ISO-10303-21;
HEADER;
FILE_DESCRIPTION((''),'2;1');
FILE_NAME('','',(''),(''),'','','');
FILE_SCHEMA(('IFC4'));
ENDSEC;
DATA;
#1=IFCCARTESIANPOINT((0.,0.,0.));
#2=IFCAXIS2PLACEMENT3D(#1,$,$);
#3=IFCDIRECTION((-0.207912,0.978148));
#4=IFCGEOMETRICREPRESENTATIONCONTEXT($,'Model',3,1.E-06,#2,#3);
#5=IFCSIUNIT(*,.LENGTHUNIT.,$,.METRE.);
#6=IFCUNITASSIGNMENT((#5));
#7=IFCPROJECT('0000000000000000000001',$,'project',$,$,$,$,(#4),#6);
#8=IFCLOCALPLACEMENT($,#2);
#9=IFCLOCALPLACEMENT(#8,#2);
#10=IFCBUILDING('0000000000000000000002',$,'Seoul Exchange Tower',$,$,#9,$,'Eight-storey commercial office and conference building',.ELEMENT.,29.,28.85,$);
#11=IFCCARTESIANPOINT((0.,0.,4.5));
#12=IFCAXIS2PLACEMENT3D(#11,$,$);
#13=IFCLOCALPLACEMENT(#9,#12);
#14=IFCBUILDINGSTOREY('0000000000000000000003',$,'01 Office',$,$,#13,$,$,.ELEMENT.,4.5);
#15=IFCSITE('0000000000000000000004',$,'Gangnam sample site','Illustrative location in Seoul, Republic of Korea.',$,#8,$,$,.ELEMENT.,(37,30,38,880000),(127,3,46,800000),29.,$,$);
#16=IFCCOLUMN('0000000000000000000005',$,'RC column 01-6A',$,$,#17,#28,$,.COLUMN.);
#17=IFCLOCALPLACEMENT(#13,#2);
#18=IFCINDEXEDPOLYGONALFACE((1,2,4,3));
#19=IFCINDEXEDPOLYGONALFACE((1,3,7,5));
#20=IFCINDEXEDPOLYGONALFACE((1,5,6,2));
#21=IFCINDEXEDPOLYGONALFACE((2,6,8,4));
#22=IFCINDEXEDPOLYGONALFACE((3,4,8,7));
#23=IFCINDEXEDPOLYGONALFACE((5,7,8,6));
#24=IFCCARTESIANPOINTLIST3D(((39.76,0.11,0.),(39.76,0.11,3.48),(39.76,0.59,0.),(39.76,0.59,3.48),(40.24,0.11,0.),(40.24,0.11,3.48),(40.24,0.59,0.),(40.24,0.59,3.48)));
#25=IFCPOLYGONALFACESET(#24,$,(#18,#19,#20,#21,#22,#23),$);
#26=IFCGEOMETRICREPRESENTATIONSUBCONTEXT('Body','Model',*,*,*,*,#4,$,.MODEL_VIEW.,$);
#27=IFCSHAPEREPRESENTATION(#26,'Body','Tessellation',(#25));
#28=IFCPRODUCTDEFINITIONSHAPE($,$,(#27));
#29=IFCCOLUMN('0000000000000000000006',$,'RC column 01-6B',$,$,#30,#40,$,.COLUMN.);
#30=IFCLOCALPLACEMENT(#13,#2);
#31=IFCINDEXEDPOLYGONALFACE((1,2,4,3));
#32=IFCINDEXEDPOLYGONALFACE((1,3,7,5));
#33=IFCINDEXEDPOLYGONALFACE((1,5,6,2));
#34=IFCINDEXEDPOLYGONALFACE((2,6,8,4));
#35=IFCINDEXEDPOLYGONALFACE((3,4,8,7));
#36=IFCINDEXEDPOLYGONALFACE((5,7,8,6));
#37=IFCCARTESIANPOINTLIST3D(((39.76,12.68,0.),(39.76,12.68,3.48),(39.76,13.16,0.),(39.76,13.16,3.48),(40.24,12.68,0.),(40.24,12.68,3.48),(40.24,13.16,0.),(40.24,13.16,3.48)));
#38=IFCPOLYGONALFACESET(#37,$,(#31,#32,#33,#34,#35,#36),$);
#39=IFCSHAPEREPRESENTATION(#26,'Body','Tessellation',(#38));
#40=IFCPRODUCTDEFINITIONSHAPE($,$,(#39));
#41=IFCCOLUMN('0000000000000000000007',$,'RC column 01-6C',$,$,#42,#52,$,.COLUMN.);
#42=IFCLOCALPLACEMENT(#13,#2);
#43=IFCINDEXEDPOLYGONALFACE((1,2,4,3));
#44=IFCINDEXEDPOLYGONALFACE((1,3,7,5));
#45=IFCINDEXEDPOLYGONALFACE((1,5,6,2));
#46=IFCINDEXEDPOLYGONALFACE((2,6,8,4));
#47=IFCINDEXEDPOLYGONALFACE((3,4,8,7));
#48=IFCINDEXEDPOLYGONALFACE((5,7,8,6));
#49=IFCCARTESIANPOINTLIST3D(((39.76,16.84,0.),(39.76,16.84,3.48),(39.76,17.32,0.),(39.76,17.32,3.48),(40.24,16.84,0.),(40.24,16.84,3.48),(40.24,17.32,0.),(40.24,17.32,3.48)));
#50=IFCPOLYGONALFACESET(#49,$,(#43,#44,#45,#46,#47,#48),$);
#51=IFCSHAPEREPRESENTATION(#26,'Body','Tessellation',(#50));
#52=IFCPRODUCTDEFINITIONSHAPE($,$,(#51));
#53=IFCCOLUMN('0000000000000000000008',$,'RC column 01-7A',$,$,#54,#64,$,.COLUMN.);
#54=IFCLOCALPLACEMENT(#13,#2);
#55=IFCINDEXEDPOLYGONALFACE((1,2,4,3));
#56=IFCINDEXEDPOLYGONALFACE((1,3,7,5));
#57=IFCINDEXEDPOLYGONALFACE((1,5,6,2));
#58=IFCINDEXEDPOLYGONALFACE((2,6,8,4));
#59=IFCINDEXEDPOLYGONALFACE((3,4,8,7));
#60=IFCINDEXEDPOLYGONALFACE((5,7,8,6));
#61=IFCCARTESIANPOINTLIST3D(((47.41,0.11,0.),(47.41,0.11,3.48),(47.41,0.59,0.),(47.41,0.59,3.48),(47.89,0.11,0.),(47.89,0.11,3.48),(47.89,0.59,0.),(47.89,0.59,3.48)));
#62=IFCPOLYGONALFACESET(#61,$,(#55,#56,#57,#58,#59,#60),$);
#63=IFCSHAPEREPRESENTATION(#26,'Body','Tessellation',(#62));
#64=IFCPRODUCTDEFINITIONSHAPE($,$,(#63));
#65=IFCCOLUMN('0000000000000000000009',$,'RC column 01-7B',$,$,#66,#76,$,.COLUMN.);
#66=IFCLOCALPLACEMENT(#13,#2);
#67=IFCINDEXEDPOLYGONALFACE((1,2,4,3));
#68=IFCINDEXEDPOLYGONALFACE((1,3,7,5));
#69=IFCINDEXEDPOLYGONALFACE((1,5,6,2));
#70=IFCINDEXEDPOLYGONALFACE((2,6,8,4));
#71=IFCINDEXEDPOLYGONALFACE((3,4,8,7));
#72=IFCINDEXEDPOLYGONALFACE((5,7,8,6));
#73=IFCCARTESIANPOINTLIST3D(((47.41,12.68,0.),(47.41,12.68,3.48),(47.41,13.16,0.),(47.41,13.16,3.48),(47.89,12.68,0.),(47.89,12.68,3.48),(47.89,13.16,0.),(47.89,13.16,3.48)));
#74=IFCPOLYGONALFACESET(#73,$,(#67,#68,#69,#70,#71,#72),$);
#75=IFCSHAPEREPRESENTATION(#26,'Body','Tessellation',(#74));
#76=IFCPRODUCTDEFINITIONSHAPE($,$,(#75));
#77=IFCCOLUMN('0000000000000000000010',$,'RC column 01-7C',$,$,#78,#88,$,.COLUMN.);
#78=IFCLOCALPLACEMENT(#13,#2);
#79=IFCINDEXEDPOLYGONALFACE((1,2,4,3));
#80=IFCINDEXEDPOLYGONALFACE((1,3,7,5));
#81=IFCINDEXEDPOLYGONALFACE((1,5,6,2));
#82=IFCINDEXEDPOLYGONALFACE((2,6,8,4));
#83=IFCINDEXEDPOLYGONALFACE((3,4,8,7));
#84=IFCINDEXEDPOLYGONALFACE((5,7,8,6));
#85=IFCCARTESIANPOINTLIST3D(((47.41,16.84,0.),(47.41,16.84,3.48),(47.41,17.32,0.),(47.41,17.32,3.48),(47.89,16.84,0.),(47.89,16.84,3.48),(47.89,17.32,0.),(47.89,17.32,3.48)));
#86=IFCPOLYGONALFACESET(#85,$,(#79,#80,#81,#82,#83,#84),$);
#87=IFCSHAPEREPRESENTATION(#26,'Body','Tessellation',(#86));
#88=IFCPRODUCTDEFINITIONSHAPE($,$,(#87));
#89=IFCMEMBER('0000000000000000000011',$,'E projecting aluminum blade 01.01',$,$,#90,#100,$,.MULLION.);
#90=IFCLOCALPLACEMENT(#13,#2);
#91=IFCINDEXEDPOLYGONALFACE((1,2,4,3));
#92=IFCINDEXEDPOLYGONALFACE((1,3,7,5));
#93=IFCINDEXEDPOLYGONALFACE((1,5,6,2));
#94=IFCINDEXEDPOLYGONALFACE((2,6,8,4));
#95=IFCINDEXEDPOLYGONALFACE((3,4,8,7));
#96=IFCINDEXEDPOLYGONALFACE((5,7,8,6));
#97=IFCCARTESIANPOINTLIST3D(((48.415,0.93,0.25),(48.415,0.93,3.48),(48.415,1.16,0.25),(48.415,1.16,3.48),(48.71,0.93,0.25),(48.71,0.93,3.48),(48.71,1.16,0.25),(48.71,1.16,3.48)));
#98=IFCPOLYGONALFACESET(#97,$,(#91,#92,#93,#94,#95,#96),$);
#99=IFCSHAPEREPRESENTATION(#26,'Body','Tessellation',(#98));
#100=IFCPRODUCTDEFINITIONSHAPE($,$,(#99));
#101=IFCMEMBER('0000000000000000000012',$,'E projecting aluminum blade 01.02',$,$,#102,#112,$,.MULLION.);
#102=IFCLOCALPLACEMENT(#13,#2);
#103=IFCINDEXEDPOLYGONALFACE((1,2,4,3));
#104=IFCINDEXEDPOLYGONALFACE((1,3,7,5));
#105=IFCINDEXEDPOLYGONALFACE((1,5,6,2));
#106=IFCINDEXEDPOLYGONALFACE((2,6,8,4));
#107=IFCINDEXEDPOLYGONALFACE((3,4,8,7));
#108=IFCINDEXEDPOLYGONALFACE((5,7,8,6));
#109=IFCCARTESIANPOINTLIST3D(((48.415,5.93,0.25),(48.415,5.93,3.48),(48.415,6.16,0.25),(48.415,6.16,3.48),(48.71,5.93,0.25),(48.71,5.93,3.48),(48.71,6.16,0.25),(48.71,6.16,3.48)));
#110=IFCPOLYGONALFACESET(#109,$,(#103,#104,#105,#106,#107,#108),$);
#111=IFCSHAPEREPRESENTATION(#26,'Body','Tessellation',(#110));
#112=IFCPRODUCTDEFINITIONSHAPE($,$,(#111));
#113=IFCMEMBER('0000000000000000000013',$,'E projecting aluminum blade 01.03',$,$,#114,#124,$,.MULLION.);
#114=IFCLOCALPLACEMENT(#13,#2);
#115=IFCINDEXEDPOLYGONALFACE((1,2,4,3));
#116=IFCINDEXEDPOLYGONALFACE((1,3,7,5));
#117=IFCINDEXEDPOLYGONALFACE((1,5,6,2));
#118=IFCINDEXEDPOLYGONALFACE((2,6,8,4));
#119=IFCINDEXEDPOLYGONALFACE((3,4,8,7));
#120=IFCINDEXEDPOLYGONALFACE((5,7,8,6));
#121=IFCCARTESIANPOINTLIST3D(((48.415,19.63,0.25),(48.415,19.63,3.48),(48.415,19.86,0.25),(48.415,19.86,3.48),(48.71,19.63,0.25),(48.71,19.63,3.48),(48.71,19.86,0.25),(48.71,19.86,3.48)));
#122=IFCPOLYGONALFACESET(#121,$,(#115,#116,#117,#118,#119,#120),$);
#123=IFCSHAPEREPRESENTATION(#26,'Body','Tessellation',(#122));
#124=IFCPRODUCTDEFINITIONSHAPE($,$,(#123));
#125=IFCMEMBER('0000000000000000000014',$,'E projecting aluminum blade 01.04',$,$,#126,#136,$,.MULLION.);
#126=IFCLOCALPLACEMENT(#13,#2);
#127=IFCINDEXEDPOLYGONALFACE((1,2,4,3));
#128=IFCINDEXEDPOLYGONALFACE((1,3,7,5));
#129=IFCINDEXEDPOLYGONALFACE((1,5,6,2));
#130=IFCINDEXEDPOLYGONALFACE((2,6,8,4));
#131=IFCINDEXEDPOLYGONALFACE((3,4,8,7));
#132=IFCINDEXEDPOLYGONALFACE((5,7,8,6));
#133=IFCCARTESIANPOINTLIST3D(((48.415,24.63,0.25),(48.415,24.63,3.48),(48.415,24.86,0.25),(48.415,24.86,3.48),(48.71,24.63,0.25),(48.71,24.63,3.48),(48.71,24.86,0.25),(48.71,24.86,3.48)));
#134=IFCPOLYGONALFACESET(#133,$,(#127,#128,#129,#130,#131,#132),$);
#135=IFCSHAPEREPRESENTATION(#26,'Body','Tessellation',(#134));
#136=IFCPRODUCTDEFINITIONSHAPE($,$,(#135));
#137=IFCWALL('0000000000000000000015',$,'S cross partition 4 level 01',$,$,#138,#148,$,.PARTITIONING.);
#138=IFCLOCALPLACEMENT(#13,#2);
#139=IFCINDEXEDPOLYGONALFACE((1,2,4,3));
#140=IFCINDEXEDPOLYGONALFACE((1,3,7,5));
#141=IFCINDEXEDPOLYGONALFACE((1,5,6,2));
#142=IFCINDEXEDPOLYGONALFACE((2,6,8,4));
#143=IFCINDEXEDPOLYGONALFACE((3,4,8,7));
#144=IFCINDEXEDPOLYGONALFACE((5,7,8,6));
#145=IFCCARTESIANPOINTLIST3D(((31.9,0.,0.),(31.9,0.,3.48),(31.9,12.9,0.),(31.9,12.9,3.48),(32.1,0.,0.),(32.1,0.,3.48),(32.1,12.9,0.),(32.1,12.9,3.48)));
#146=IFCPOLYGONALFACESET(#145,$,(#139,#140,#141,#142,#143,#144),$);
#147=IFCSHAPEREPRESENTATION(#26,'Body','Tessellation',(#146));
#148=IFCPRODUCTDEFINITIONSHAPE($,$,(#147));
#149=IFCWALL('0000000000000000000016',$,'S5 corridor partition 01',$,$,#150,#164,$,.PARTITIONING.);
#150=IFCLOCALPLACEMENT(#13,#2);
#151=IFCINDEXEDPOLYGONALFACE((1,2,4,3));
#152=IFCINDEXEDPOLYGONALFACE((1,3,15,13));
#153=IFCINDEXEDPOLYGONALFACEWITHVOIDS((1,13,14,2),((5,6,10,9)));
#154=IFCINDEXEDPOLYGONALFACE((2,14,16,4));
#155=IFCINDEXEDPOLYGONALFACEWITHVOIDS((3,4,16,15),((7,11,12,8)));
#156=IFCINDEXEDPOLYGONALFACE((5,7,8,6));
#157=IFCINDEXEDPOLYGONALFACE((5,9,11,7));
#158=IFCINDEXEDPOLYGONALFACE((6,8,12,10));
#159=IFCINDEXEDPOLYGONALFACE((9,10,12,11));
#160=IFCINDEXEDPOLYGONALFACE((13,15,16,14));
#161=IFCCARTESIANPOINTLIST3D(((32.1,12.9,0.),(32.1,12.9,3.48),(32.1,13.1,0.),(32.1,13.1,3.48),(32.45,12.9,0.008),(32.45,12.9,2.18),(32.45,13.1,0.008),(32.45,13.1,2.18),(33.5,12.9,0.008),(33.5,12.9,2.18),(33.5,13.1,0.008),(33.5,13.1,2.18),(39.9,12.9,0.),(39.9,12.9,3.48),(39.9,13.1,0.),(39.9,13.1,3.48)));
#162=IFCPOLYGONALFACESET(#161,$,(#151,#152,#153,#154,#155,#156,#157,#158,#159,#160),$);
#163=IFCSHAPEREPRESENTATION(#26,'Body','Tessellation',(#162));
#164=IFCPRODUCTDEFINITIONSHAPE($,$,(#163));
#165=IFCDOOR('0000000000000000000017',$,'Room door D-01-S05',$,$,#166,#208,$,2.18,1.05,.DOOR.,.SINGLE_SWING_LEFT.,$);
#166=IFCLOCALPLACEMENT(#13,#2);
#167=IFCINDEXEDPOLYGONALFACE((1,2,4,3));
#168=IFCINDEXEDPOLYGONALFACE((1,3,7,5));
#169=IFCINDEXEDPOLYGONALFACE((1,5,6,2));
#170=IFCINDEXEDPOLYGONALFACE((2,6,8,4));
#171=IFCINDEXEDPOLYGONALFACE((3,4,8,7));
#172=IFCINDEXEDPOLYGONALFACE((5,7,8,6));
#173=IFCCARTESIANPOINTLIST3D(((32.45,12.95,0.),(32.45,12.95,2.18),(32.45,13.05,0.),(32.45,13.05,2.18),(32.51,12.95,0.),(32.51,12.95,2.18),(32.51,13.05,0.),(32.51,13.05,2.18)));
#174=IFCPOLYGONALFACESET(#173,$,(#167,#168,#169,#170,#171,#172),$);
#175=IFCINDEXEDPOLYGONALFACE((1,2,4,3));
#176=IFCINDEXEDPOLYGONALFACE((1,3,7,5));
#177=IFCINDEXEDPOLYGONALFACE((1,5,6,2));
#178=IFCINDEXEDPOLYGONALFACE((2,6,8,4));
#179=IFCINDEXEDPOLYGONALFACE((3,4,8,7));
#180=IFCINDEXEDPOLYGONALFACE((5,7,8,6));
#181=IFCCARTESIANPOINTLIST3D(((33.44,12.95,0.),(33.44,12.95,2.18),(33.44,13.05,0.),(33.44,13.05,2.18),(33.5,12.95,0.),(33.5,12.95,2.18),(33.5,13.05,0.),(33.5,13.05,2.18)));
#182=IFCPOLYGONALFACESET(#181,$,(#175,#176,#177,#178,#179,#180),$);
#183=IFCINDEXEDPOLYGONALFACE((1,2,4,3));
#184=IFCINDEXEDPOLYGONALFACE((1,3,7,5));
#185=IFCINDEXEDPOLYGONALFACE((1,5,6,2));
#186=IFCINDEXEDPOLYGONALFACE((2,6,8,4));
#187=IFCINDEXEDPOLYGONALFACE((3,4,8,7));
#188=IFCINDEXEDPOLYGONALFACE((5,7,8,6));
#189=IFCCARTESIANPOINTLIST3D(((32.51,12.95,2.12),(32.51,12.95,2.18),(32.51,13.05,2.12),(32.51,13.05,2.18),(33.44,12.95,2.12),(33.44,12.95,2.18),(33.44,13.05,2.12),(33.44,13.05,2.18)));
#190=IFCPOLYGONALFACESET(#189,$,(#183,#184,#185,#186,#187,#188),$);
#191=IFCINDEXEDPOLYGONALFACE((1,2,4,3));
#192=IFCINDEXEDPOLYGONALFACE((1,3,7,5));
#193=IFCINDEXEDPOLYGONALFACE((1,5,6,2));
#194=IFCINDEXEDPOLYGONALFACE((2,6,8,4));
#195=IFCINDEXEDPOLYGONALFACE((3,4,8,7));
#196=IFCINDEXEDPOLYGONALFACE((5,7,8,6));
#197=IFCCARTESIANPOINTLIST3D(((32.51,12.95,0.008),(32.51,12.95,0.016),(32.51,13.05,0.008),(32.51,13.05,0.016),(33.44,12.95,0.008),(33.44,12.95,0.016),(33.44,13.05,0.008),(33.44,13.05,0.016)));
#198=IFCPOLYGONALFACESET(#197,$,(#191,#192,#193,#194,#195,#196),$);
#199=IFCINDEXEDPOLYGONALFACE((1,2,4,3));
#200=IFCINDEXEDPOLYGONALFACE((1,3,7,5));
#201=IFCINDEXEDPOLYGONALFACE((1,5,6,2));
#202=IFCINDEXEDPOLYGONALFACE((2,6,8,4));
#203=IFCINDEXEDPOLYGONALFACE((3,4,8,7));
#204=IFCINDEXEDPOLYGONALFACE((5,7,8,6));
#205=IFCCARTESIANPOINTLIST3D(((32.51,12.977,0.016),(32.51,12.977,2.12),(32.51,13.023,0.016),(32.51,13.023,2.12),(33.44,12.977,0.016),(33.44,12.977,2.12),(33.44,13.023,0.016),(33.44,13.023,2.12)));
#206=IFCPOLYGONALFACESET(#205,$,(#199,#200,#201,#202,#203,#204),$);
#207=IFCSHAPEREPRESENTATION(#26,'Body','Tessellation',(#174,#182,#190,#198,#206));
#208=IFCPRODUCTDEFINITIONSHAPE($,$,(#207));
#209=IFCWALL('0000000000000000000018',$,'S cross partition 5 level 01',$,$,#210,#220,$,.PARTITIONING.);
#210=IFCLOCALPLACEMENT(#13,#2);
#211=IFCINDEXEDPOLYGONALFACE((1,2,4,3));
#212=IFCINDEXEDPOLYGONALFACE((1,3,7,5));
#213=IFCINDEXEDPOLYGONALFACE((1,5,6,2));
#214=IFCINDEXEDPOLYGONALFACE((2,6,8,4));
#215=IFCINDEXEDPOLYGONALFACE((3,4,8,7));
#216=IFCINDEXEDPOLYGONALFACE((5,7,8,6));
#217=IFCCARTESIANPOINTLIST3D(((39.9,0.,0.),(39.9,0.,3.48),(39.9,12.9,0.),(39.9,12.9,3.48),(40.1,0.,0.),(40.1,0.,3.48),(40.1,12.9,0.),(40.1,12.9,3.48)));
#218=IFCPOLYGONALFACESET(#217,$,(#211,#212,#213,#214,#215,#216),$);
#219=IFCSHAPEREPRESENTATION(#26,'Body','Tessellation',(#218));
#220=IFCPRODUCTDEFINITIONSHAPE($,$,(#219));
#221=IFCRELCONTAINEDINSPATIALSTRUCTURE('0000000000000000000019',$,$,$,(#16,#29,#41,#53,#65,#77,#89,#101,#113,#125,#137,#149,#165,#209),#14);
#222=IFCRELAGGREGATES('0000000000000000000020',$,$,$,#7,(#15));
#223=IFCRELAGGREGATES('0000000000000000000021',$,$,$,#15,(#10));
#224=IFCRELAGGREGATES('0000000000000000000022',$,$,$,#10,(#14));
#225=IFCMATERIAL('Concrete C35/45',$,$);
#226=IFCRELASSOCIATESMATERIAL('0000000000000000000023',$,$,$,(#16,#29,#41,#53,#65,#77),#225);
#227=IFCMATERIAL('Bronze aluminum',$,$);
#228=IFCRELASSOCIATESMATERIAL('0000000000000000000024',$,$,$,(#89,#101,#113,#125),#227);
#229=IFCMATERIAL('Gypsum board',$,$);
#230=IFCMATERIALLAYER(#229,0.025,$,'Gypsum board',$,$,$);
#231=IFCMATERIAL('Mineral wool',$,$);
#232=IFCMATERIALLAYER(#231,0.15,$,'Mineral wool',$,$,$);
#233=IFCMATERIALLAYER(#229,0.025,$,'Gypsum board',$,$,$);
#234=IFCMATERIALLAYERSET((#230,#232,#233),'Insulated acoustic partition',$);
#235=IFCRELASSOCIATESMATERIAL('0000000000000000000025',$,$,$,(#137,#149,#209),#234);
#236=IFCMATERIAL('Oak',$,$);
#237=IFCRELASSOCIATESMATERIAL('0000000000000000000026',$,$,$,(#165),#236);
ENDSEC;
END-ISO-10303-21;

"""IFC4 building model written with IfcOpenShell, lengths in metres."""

from ifc_helpers import new_model, si_unit, direction, frame, frame_2d, origin, place, context, subcontext, project, spatial, rectangle, extrude, material, layer, layer_set, layer_usage, element, fill, save


model = new_model("IFC4")

# Units and contexts
model_context = context("Model", 3, precision=1e-06, world=origin(), true_north=direction((-0.207912, 0.978148)))
body_context = subcontext(model_context, "Body", "Model", "MODEL_VIEW")
ifc_project = project(units=[si_unit("LENGTHUNIT", "METRE")], contexts=[model_context])

# Site, building, storey
site_placement = place(None, origin())
site = spatial("IfcSite", under=ifc_project, at=site_placement, Name="Gangnam sample site", Description="Illustrative location in Seoul, Republic of Korea.", CompositionType="ELEMENT", RefLatitude=(37, 30, 38, 880000), RefLongitude=(127, 3, 46, 800000), RefElevation=29.0)
building_placement = place(site_placement, origin())
building = spatial("IfcBuilding", under=site, at=building_placement, Name="Seoul Exchange Tower", LongName="Eight-storey commercial office and conference building", CompositionType="ELEMENT", ElevationOfRefHeight=29.0, ElevationOfTerrain=28.85)
storey_placement = place(building_placement, frame((0.0, 0.0, 4.5)))
storey = spatial("IfcBuildingStorey", under=building, at=storey_placement, Name="01 Office", CompositionType="ELEMENT", Elevation=4.5)

# Columns
ifc_material_1 = material(Name="Concrete C35/45")
for number, where, name in (
    (1, (39.76, 0.11, 0.0), "RC column 01-6A"),
    (2, (39.76, 12.68, 0.0), "RC column 01-6B"),
    (3, (39.76, 16.84, 0.0), "RC column 01-6C"),
    (4, (47.41, 0.11, 0.0), "RC column 01-7A"),
    (5, (47.41, 12.68, 0.0), "RC column 01-7B"),
    (6, (47.41, 16.84, 0.0), "RC column 01-7C"),
):
    element("IfcColumn", number, at=place(storey_placement, frame(where)), inside=storey, material=ifc_material_1, Name=name, PredefinedType="COLUMN", context=body_context, shape_type="SweptSolid", body=[
        extrude(rectangle(XDim=0.48, YDim=0.48, at=frame_2d((0.24, 0.24))), origin(), (0.0, 0.0, 1.0), 3.48),
    ])

# Members
ifc_material_2 = material(Name="Bronze aluminum")
wall_1_placement = place(storey_placement, frame((48.4, 0.0, 0.0), z_axis=(0.0, 0.0, 1.0), x_axis=(0.0, 1.0, 0.0)))
placement_1 = place(wall_1_placement, origin())
element("IfcMember", 7, at=placement_1, inside=storey, material=ifc_material_2, Name="E projecting aluminum blade 01.01", PredefinedType="MULLION", context=body_context, shape_type="SweptSolid", body=[
    extrude(rectangle(XDim=0.23, YDim=0.295, at=frame_2d((0.115, 0.1475))), frame((0.93, -0.31, 0.25)), (0.0, 0.0, 1.0), 3.23),
])
element("IfcMember", 8, at=placement_1, inside=storey, material=ifc_material_2, Name="E projecting aluminum blade 01.02", PredefinedType="MULLION", context=body_context, shape_type="SweptSolid", body=[
    extrude(rectangle(XDim=0.23, YDim=0.295, at=frame_2d((0.115, 0.1475))), frame((5.93, -0.31, 0.25)), (0.0, 0.0, 1.0), 3.23),
])
element("IfcMember", 9, at=placement_1, inside=storey, material=ifc_material_2, Name="E projecting aluminum blade 01.03", PredefinedType="MULLION", context=body_context, shape_type="SweptSolid", body=[
    extrude(rectangle(XDim=0.23, YDim=0.295, at=frame_2d((0.115, 0.1475))), frame((19.63, -0.31, 0.25)), (0.0, 0.0, 1.0), 3.23),
])
element("IfcMember", 10, at=placement_1, inside=storey, material=ifc_material_2, Name="E projecting aluminum blade 01.04", PredefinedType="MULLION", context=body_context, shape_type="SweptSolid", body=[
    extrude(rectangle(XDim=0.23, YDim=0.295, at=frame_2d((0.115, 0.1475))), frame((24.63, -0.31, 0.25)), (0.0, 0.0, 1.0), 3.23),
])

# Shared definitions
ifc_material_3 = material(Name="Mineral wool")
ifc_material_4 = material(Name="Gypsum board")

# Wall
ifc_layer_1 = layer(ifc_material_4, 0.025, Name="Gypsum board")
ifc_layer_2 = layer(ifc_material_3, 0.15, Name="Mineral wool")
ifc_layer_3 = layer(ifc_material_4, 0.025, Name="Gypsum board")
ifc_layer_set_1 = layer_set([ifc_layer_1, ifc_layer_2, ifc_layer_3], Name="Insulated acoustic partition")
ifc_layer_usage_1 = layer_usage(ifc_layer_set_1, "AXIS2", "POSITIVE", 0.0)
wall_2_placement = place(storey_placement, frame((32.1, 0.0, 0.0), z_axis=(0.0, 0.0, 1.0), x_axis=(0.0, 1.0, 0.0)))
element("IfcWall", 11, at=wall_2_placement, inside=storey, material=ifc_layer_usage_1, Name="S cross partition 4 level 01", PredefinedType="PARTITIONING", context=body_context, shape_type="SweptSolid", body=[
    extrude(rectangle(XDim=12.9, YDim=0.2, at=frame_2d((6.45, 0.1))), origin(), (0.0, 0.0, 1.0), 3.48),
])

# Wall, opening, door
wall_3_placement = place(storey_placement, frame((32.1, 12.9, 0.0)))
wall_3 = element("IfcWall", 12, at=wall_3_placement, inside=storey, material=ifc_layer_usage_1, Name="S5 corridor partition 01", PredefinedType="PARTITIONING", context=body_context, shape_type="SweptSolid", body=[
    extrude(rectangle(XDim=7.8, YDim=0.2, at=frame_2d((3.9, 0.1))), origin(), (0.0, 0.0, 1.0), 3.48),
])
placement_2 = place(wall_3_placement, origin())
opening_1 = element("IfcOpeningElement", 13, at=placement_2, cuts=wall_3, PredefinedType="OPENING", context=body_context, shape_type="SweptSolid", body=[
    extrude(rectangle(XDim=1.05, YDim=0.24, at=frame_2d((0.525, 0.12))), frame((0.35, -0.02, 0.008)), (0.0, 0.0, 1.0), 2.172),
])
ifc_material_5 = material(Name="Oak")
door_1 = element("IfcDoor", 14, at=placement_2, inside=storey, material=ifc_material_5, Name="Room door D-01-S05", OperationType="SINGLE_SWING_LEFT", OverallHeight=2.18, OverallWidth=1.05, PredefinedType="DOOR", context=body_context, shape_type="SweptSolid", body=[
    extrude(rectangle(XDim=0.06, YDim=0.1, at=frame_2d((0.03, 0.05))), frame((0.35, 0.05, 0.0)), (0.0, 0.0, 1.0), 2.18),
    extrude(rectangle(XDim=0.06, YDim=0.1, at=frame_2d((0.03, 0.05))), frame((1.34, 0.05, 0.0)), (0.0, 0.0, 1.0), 2.18),
    extrude(rectangle(XDim=0.93, YDim=0.1, at=frame_2d((0.465, 0.05))), frame((0.41, 0.05, 2.12)), (0.0, 0.0, 1.0), 0.06),
    extrude(rectangle(XDim=0.93, YDim=0.1, at=frame_2d((0.465, 0.05))), frame((0.41, 0.05, 0.008)), (0.0, 0.0, 1.0), 0.008),
    extrude(rectangle(XDim=0.93, YDim=0.046, at=frame_2d((0.465, 0.023))), frame((0.41, 0.077, 0.016)), (0.0, 0.0, 1.0), 2.104),
])
fill(opening_1, door_1)

# Wall
wall_4_placement = place(storey_placement, frame((40.1, 0.0, 0.0), z_axis=(0.0, 0.0, 1.0), x_axis=(0.0, 1.0, 0.0)))
element("IfcWall", 15, at=wall_4_placement, inside=storey, material=ifc_layer_usage_1, Name="S cross partition 5 level 01", PredefinedType="PARTITIONING", context=body_context, shape_type="SweptSolid", body=[
    extrude(rectangle(XDim=12.9, YDim=0.2, at=frame_2d((6.45, 0.1))), origin(), (0.0, 0.0, 1.0), 3.48),
])

save(model, "model.ifc")
